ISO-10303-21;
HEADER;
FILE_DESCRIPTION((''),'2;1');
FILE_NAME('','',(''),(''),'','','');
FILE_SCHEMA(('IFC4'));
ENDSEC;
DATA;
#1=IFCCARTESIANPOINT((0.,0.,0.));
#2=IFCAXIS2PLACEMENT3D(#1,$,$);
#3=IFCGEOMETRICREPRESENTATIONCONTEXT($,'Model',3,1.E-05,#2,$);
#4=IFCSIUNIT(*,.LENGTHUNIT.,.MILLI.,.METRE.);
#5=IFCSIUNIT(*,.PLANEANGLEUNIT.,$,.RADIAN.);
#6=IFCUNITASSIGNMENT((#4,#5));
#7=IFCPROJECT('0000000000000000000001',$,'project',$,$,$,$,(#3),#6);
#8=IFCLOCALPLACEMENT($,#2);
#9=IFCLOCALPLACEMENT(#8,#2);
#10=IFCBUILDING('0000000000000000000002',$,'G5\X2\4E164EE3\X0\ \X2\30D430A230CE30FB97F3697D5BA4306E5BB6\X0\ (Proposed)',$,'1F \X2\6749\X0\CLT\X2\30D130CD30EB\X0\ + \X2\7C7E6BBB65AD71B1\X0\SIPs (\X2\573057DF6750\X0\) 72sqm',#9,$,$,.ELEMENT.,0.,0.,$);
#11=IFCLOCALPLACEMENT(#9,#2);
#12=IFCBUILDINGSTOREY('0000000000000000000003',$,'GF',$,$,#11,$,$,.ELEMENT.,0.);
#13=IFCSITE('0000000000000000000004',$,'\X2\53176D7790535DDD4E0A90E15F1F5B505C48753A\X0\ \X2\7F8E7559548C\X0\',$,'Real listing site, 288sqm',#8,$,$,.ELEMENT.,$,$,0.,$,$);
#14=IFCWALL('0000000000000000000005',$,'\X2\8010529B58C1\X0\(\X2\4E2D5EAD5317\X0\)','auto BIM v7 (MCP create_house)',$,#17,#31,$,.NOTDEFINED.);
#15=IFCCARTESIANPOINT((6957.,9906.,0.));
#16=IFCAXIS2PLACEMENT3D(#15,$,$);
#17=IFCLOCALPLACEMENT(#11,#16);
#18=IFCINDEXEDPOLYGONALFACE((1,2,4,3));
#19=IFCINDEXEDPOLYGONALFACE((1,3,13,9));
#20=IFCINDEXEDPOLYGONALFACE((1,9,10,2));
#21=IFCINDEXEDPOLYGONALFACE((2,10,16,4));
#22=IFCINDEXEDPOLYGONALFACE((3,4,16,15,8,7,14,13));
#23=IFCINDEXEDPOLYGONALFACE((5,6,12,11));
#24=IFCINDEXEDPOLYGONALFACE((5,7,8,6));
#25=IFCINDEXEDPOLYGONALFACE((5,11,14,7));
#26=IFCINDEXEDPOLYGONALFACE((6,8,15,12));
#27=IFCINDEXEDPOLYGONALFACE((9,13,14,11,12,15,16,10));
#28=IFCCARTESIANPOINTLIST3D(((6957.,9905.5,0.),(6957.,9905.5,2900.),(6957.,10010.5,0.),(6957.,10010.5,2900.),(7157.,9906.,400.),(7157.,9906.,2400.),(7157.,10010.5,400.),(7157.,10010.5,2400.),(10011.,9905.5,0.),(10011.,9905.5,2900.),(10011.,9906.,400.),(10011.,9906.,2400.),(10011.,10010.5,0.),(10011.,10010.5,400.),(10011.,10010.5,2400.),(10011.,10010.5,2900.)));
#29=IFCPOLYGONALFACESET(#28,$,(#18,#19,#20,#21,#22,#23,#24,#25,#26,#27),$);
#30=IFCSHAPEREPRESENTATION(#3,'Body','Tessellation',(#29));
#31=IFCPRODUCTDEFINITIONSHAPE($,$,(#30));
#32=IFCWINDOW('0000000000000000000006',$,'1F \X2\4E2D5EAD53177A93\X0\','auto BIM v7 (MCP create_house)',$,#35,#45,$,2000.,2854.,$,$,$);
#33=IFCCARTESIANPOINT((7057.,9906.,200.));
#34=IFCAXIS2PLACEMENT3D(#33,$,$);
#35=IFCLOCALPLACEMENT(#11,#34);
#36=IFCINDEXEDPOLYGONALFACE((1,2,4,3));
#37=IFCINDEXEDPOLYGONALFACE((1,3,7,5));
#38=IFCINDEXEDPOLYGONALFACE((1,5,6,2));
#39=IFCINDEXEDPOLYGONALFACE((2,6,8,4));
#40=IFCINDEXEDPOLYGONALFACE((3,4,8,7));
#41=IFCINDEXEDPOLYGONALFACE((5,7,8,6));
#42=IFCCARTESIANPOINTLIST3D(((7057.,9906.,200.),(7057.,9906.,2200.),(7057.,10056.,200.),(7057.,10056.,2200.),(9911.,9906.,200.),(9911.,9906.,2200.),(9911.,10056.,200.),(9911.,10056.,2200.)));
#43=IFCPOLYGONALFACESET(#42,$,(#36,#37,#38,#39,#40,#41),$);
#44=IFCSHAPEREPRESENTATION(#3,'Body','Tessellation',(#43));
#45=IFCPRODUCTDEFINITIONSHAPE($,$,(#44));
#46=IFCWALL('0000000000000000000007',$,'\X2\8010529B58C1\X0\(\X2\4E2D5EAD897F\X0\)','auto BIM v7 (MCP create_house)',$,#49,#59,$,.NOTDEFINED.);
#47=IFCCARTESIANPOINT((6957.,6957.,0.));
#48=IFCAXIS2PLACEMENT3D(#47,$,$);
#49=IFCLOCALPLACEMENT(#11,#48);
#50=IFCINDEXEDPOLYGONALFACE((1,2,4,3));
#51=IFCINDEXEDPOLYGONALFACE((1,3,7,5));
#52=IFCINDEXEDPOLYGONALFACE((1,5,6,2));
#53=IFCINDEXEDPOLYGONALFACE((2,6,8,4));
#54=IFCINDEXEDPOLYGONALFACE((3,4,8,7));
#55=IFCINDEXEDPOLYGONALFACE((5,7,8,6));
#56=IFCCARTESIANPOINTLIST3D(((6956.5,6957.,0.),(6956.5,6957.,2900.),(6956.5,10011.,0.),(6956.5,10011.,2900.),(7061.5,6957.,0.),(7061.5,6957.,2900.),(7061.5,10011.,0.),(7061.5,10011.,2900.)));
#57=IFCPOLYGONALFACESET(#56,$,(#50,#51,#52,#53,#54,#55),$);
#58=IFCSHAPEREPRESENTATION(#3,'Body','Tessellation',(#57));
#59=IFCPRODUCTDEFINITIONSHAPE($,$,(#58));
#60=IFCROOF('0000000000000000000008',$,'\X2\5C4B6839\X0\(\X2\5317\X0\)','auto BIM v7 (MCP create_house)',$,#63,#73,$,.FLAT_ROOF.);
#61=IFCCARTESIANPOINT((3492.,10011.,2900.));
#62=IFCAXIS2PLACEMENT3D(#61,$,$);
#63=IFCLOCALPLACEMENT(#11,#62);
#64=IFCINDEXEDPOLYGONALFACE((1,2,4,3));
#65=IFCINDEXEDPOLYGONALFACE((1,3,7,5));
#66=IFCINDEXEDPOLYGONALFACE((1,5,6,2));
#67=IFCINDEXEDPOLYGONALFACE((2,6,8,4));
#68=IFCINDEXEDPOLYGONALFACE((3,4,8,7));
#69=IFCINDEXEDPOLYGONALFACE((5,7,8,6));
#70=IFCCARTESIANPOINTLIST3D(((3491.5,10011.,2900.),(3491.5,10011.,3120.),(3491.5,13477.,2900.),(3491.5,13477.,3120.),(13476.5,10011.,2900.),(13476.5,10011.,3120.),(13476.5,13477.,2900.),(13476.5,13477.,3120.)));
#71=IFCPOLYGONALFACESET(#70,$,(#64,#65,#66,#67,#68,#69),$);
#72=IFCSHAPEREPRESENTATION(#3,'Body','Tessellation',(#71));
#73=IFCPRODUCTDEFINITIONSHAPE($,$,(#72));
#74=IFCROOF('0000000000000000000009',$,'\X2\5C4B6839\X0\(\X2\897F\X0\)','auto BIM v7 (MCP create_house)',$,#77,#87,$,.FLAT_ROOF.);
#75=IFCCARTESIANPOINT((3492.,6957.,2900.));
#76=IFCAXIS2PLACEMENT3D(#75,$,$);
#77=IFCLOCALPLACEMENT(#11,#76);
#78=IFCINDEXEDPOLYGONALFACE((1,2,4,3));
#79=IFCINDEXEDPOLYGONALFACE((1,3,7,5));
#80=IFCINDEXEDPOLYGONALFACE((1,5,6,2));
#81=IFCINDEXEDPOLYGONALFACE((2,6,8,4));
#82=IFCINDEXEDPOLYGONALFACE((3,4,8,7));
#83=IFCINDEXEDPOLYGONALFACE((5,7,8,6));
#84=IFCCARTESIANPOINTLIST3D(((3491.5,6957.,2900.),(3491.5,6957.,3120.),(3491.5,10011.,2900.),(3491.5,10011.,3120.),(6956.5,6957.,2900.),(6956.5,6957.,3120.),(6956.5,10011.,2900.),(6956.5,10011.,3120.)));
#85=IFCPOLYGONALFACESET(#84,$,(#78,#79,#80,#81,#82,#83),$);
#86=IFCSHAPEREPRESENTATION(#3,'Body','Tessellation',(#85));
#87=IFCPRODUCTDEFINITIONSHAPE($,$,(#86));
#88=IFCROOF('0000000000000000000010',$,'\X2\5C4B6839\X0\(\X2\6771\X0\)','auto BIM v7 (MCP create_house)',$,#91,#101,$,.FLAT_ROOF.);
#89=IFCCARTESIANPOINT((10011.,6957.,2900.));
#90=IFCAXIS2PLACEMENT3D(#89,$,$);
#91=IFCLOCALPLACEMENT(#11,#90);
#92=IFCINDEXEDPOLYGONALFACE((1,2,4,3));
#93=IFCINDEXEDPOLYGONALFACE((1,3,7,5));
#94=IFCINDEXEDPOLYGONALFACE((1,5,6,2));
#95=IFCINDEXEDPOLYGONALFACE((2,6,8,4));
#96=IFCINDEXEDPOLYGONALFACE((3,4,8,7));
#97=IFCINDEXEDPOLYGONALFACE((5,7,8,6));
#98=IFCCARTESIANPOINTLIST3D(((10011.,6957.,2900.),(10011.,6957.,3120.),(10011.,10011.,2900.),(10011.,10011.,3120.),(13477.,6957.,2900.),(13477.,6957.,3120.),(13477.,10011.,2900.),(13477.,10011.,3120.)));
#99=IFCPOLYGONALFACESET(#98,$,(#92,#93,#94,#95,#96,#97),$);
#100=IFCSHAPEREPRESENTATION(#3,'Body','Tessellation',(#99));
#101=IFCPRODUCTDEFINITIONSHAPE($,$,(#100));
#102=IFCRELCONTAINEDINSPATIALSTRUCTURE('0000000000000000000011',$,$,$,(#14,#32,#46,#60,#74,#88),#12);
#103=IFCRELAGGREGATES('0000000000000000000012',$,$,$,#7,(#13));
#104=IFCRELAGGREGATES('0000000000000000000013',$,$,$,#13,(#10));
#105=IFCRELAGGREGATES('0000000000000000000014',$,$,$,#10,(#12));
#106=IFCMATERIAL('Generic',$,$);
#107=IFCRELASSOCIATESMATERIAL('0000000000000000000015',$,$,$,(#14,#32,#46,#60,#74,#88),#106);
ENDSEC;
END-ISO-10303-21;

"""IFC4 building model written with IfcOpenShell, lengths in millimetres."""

from ifc_helpers import new_model, si_unit, frame, frame_2d, origin, place, context, project, spatial, rectangle, extrude, material, element, fill, save


model = new_model("IFC4")

# Units and contexts
model_context = context("Model", 3, precision=1e-05, world=origin())
ifc_project = project(units=[si_unit("LENGTHUNIT", "METRE", prefix="MILLI"), si_unit("PLANEANGLEUNIT", "RADIAN")], contexts=[model_context])

# Site, building, storey
site_placement = place(None, origin())
site = spatial("IfcSite", under=ifc_project, at=site_placement, Name="北海道川上郡弟子屈町 美留和", ObjectType="Real listing site, 288sqm", CompositionType="ELEMENT", RefElevation=0.0)
building_placement = place(site_placement, origin())
building = spatial("IfcBuilding", under=site, at=building_placement, Name="G5世代 ピアノ・音楽室の家 (Proposed)", ObjectType="1F 杉CLTパネル + 籾殻断熱SIPs (地域材) 72sqm", CompositionType="ELEMENT", ElevationOfRefHeight=0.0, ElevationOfTerrain=0.0)
storey_placement = place(building_placement, origin())
storey = spatial("IfcBuildingStorey", under=building, at=storey_placement, Name="GF", CompositionType="ELEMENT", Elevation=0.0)

# Shared definitions
ifc_material = material(Name="Generic")

# Wall, opening, window
wall_1_placement = place(storey_placement, frame((6957.0, 9906.0, 0.0)))
wall_1 = element("IfcWall", 1, at=wall_1_placement, inside=storey, material=ifc_material, Name="耐力壁(中庭北)", Description="auto BIM v7 (MCP create_house)", PredefinedType="NOTDEFINED", context=model_context, shape_type="SweptSolid", body=[
    extrude(rectangle(XDim=3054.0, YDim=105.0, at=frame_2d((1527.0, 52.0))), frame((6957.0, 9906.0, 0.0)), (0.0, 0.0, 1.0), 2900.0),
])
opening_1_placement = place(storey_placement, frame((7057.0, 9906.0, 200.0)))
opening_1 = element("IfcOpeningElement", 2, at=opening_1_placement, cuts=wall_1, PredefinedType="NOTDEFINED", context=model_context, shape_type="SweptSolid", body=[
    extrude(rectangle(XDim=2854.0, YDim=150.0, at=frame_2d((1427.0, 75.0))), frame((7057.0, 9906.0, 200.0)), (0.0, 0.0, 1.0), 2000.0),
])
window_1_placement = place(storey_placement, frame((7057.0, 9906.0, 200.0)))
window_1 = element("IfcWindow", 3, at=window_1_placement, inside=storey, material=ifc_material, Name="1F 中庭北窓", Description="auto BIM v7 (MCP create_house)", OverallHeight=2000.0, OverallWidth=2854.0, context=model_context, shape_type="SweptSolid", body=[
    extrude(rectangle(XDim=2854.0, YDim=150.0, at=frame_2d((1427.0, 75.0))), frame((7057.0, 9906.0, 200.0)), (0.0, 0.0, 1.0), 2000.0),
])
fill(opening_1, window_1)

# Wall
wall_2_placement = place(storey_placement, frame((6957.0, 6957.0, 0.0)))
element("IfcWall", 4, at=wall_2_placement, inside=storey, material=ifc_material, Name="耐力壁(中庭西)", Description="auto BIM v7 (MCP create_house)", PredefinedType="NOTDEFINED", context=model_context, shape_type="SweptSolid", body=[
    extrude(rectangle(XDim=105.0, YDim=3054.0, at=frame_2d((52.0, 1527.0))), frame((6957.0, 6957.0, 0.0)), (0.0, 0.0, 1.0), 2900.0),
])

# Roofs
roof_1_placement = place(storey_placement, frame((3492.0, 10011.0, 2900.0)))
element("IfcRoof", 5, at=roof_1_placement, inside=storey, material=ifc_material, Name="屋根(北)", Description="auto BIM v7 (MCP create_house)", PredefinedType="FLAT_ROOF", context=model_context, shape_type="SweptSolid", body=[
    extrude(rectangle(XDim=9985.0, YDim=3466.0, at=frame_2d((4992.0, 1733.0))), frame((3492.0, 10011.0, 2900.0)), (0.0, 0.0, 1.0), 220.0),
])
roof_2_placement = place(storey_placement, frame((3492.0, 6957.0, 2900.0)))
element("IfcRoof", 6, at=roof_2_placement, inside=storey, material=ifc_material, Name="屋根(西)", Description="auto BIM v7 (MCP create_house)", PredefinedType="FLAT_ROOF", context=model_context, shape_type="SweptSolid", body=[
    extrude(rectangle(XDim=3465.0, YDim=3054.0, at=frame_2d((1732.0, 1527.0))), frame((3492.0, 6957.0, 2900.0)), (0.0, 0.0, 1.0), 220.0),
])
roof_3_placement = place(storey_placement, frame((10011.0, 6957.0, 2900.0)))
element("IfcRoof", 7, at=roof_3_placement, inside=storey, material=ifc_material, Name="屋根(東)", Description="auto BIM v7 (MCP create_house)", PredefinedType="FLAT_ROOF", context=model_context, shape_type="SweptSolid", body=[
    extrude(rectangle(XDim=3466.0, YDim=3054.0, at=frame_2d((1733.0, 1527.0))), frame((10011.0, 6957.0, 2900.0)), (0.0, 0.0, 1.0), 220.0),
])

save(model, "model.ifc")
